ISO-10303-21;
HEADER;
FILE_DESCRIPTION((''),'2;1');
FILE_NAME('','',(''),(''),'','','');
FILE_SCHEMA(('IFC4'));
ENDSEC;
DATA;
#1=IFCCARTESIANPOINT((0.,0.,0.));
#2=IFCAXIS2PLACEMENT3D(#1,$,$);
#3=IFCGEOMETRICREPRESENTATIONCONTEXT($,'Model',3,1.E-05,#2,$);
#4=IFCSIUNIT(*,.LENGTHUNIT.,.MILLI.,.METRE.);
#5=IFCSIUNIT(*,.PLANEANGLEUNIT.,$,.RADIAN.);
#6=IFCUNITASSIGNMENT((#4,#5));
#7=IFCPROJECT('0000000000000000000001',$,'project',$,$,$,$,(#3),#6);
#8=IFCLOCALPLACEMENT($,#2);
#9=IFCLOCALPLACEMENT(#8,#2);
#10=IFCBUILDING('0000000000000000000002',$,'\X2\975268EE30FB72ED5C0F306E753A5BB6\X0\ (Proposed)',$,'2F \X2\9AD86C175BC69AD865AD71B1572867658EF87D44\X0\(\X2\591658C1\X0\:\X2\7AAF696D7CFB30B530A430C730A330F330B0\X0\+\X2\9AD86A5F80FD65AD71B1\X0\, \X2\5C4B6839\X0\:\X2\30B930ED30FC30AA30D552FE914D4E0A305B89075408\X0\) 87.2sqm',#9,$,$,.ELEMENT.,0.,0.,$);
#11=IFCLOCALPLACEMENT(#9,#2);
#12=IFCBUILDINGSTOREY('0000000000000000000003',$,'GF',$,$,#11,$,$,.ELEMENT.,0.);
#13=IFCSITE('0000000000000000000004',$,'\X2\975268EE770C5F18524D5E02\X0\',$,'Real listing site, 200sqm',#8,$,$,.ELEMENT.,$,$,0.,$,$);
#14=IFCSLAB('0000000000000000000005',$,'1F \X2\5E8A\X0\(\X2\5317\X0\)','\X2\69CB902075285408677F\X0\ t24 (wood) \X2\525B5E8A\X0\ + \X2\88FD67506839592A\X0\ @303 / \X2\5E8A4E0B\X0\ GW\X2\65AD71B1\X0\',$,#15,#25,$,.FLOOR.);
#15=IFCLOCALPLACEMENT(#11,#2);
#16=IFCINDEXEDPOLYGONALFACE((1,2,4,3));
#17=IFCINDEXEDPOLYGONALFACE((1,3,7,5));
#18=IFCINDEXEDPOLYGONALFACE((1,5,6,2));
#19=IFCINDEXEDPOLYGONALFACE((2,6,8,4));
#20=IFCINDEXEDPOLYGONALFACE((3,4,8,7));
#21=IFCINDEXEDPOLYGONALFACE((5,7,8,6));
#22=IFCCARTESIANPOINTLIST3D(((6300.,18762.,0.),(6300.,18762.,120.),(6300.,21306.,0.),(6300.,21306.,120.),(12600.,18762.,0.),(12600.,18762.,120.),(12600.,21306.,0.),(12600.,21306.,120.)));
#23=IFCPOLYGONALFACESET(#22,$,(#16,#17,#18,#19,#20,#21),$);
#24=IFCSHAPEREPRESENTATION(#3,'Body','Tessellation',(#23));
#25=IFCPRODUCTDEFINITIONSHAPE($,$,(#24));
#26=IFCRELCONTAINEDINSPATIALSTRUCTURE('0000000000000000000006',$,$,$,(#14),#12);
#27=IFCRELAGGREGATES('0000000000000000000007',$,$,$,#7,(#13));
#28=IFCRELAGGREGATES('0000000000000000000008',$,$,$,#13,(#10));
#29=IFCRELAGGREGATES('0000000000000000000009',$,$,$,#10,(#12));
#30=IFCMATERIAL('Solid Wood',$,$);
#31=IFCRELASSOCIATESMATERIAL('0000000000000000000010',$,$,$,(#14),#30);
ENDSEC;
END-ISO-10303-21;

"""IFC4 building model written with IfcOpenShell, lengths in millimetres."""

from ifc_helpers import new_model, si_unit, frame, frame_2d, origin, place, context, project, spatial, rectangle, extrude, material, element, save


model = new_model("IFC4")

# Units and contexts
model_context = context("Model", 3, precision=1e-05, world=origin())
ifc_project = project(units=[si_unit("LENGTHUNIT", "METRE", prefix="MILLI"), si_unit("PLANEANGLEUNIT", "RADIAN")], contexts=[model_context])

# Site, building, storey
site_placement = place(None, origin())
site = spatial("IfcSite", under=ifc_project, at=site_placement, Name="青森県弘前市", ObjectType="Real listing site, 200sqm", CompositionType="ELEMENT", RefElevation=0.0)
building_placement = place(site_placement, origin())
building = spatial("IfcBuilding", under=site, at=building_placement, Name="青森・狭小の町家 (Proposed)", ObjectType="2F 高気密高断熱在来軸組(外壁:窯業系サイディング+高機能断熱, 屋根:スローオフ勾配上せ複合) 87.2sqm", CompositionType="ELEMENT", ElevationOfRefHeight=0.0, ElevationOfTerrain=0.0)
storey_placement = place(building_placement, origin())
storey = spatial("IfcBuildingStorey", under=building, at=storey_placement, Name="GF", CompositionType="ELEMENT", Elevation=0.0)

# Shared definitions
ifc_material_1 = material(Name="Solid Wood")

# Slab
slab_placement = place(storey_placement, frame((3150.0, 9381.0, 0.0)))
element("IfcSlab", 1, at=slab_placement, inside=storey, material=ifc_material_1, Name="1F 床(北)", Description="構造用合板 t24 (wood) 剛床 + 製材根太 @303 / 床下 GW断熱", PredefinedType="FLOOR", context=model_context, shape_type="SweptSolid", body=[
    extrude(rectangle(XDim=6300.0, YDim=2544.0, at=frame_2d((3150.0, 1272.0))), frame((3150.0, 9381.0, 0.0)), (0.0, 0.0, 1.0), 120.0),
])

save(model, "model.ifc")
